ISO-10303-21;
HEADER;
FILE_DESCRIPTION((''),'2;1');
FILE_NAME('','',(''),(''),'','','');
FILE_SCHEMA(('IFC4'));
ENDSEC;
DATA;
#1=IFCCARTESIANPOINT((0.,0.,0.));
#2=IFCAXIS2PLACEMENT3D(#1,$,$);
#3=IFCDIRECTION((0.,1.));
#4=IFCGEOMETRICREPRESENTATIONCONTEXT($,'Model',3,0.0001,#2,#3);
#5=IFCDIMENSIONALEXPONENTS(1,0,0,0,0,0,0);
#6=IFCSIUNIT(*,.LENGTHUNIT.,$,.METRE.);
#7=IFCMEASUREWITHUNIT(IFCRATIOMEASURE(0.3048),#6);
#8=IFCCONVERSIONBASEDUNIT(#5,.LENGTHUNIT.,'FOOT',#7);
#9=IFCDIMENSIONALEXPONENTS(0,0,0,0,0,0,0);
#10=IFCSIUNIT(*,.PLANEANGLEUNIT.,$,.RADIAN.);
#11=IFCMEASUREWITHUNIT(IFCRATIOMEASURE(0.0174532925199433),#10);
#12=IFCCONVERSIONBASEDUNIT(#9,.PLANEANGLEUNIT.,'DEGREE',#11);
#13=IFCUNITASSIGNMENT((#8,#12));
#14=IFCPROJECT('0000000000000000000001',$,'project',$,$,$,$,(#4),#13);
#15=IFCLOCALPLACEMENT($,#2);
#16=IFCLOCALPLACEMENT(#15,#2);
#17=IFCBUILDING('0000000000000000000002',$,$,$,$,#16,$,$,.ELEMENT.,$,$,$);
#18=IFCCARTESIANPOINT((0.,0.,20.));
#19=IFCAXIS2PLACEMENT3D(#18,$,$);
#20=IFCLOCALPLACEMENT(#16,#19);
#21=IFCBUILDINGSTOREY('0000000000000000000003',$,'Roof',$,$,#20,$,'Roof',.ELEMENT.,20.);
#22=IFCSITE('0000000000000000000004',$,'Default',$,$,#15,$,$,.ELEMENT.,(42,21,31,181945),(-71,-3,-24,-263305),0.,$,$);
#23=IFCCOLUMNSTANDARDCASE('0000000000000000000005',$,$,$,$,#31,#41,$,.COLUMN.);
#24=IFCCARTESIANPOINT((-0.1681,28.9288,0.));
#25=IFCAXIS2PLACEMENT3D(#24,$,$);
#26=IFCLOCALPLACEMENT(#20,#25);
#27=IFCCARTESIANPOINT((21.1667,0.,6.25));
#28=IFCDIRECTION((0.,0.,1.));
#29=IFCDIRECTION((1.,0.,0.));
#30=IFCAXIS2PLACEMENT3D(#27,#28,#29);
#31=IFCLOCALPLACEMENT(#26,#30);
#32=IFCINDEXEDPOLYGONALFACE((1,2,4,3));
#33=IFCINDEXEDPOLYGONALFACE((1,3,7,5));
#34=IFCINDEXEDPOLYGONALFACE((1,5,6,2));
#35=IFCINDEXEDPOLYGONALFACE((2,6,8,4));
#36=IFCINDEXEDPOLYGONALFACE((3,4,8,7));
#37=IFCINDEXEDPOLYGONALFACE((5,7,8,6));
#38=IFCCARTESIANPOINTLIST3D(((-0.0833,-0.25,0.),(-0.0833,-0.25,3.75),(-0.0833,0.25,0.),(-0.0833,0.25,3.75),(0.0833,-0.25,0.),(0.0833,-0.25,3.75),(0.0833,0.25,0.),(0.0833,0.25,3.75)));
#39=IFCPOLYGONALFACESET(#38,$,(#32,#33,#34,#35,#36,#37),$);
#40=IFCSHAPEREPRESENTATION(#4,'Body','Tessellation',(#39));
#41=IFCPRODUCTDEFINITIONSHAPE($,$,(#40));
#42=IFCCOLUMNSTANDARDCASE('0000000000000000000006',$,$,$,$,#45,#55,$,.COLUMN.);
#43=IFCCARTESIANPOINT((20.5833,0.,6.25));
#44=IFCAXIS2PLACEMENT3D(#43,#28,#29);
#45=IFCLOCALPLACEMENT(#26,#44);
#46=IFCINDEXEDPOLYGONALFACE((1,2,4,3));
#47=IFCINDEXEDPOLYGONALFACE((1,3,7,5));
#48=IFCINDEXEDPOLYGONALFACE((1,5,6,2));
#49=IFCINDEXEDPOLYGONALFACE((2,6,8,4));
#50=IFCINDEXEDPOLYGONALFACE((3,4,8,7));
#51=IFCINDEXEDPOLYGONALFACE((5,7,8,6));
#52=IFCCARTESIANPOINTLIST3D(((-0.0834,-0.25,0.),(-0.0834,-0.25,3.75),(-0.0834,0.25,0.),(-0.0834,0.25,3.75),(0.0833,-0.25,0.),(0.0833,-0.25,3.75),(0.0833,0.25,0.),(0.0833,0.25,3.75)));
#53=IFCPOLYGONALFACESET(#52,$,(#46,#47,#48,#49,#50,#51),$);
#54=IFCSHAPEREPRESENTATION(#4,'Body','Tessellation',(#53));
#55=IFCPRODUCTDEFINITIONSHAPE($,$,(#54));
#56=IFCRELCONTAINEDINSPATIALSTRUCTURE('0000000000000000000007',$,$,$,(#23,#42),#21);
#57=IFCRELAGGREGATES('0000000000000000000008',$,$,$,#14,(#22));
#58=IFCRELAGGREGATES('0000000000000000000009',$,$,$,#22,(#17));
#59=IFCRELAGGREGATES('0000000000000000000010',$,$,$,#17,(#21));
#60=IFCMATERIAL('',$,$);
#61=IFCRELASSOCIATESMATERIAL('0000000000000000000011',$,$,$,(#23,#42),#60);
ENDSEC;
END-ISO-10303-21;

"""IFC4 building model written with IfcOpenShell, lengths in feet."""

from ifc_helpers import new_model, entity, si_unit, converted_unit, direction, frame, origin, place, context, project, spatial, rectangle, extrude, material, element, save


model = new_model("IFC4")

# Units and contexts
model_context = context("Model", 3, precision=0.0001, world=origin(), true_north=direction((0.0, 1.0)))
ifc_project = project(units=[converted_unit("LENGTHUNIT", "FOOT", entity("IfcRatioMeasure", 0.3048), si_unit("LENGTHUNIT", "METRE"), dimensions=[1, 0, 0, 0, 0, 0, 0]), converted_unit("PLANEANGLEUNIT", "DEGREE", entity("IfcRatioMeasure", 0.0174532925199433), si_unit("PLANEANGLEUNIT", "RADIAN"), dimensions=[0, 0, 0, 0, 0, 0, 0])], contexts=[model_context])

# Site, building, storey
site_placement = place(None, origin())
site = spatial("IfcSite", under=ifc_project, at=site_placement, Name="Default", CompositionType="ELEMENT", RefLatitude=(42, 21, 31, 181945), RefLongitude=(-71, -3, -24, -263305), RefElevation=0.0)
building_placement = place(site_placement, origin())
building = spatial("IfcBuilding", under=site, at=building_placement, CompositionType="ELEMENT")
storey_placement = place(building_placement, frame((0.0, 0.0, 20.0)))
storey = spatial("IfcBuildingStorey", under=building, at=storey_placement, Name="Roof", LongName="Roof", CompositionType="ELEMENT", Elevation=20.0)

# Columns
ifc_material_1 = material(Name="")
placement = place(storey_placement, frame((-0.1681, 28.9288, 0.0)))
for number, where, z_axis, x_axis in (
    (1, (21.1667, 0.0, 6.25), (0.0, 0.0, 1.0), (1.0, 0.0, 0.0)),
    (2, (20.5833, 0.0, 6.25), (0.0, 0.0, 1.0), (1.0, 0.0, 0.0)),
):
    element("IfcColumnStandardCase", number, at=place(placement, frame(where, z_axis=z_axis, x_axis=x_axis)), inside=storey, material=ifc_material_1, PredefinedType="COLUMN", context=model_context, shape_type="SweptSolid", body=[
        extrude(rectangle(XDim=0.1667, YDim=0.5), origin(), (0.0, 0.0, 1.0), 3.75),
    ])

save(model, "model.ifc")
